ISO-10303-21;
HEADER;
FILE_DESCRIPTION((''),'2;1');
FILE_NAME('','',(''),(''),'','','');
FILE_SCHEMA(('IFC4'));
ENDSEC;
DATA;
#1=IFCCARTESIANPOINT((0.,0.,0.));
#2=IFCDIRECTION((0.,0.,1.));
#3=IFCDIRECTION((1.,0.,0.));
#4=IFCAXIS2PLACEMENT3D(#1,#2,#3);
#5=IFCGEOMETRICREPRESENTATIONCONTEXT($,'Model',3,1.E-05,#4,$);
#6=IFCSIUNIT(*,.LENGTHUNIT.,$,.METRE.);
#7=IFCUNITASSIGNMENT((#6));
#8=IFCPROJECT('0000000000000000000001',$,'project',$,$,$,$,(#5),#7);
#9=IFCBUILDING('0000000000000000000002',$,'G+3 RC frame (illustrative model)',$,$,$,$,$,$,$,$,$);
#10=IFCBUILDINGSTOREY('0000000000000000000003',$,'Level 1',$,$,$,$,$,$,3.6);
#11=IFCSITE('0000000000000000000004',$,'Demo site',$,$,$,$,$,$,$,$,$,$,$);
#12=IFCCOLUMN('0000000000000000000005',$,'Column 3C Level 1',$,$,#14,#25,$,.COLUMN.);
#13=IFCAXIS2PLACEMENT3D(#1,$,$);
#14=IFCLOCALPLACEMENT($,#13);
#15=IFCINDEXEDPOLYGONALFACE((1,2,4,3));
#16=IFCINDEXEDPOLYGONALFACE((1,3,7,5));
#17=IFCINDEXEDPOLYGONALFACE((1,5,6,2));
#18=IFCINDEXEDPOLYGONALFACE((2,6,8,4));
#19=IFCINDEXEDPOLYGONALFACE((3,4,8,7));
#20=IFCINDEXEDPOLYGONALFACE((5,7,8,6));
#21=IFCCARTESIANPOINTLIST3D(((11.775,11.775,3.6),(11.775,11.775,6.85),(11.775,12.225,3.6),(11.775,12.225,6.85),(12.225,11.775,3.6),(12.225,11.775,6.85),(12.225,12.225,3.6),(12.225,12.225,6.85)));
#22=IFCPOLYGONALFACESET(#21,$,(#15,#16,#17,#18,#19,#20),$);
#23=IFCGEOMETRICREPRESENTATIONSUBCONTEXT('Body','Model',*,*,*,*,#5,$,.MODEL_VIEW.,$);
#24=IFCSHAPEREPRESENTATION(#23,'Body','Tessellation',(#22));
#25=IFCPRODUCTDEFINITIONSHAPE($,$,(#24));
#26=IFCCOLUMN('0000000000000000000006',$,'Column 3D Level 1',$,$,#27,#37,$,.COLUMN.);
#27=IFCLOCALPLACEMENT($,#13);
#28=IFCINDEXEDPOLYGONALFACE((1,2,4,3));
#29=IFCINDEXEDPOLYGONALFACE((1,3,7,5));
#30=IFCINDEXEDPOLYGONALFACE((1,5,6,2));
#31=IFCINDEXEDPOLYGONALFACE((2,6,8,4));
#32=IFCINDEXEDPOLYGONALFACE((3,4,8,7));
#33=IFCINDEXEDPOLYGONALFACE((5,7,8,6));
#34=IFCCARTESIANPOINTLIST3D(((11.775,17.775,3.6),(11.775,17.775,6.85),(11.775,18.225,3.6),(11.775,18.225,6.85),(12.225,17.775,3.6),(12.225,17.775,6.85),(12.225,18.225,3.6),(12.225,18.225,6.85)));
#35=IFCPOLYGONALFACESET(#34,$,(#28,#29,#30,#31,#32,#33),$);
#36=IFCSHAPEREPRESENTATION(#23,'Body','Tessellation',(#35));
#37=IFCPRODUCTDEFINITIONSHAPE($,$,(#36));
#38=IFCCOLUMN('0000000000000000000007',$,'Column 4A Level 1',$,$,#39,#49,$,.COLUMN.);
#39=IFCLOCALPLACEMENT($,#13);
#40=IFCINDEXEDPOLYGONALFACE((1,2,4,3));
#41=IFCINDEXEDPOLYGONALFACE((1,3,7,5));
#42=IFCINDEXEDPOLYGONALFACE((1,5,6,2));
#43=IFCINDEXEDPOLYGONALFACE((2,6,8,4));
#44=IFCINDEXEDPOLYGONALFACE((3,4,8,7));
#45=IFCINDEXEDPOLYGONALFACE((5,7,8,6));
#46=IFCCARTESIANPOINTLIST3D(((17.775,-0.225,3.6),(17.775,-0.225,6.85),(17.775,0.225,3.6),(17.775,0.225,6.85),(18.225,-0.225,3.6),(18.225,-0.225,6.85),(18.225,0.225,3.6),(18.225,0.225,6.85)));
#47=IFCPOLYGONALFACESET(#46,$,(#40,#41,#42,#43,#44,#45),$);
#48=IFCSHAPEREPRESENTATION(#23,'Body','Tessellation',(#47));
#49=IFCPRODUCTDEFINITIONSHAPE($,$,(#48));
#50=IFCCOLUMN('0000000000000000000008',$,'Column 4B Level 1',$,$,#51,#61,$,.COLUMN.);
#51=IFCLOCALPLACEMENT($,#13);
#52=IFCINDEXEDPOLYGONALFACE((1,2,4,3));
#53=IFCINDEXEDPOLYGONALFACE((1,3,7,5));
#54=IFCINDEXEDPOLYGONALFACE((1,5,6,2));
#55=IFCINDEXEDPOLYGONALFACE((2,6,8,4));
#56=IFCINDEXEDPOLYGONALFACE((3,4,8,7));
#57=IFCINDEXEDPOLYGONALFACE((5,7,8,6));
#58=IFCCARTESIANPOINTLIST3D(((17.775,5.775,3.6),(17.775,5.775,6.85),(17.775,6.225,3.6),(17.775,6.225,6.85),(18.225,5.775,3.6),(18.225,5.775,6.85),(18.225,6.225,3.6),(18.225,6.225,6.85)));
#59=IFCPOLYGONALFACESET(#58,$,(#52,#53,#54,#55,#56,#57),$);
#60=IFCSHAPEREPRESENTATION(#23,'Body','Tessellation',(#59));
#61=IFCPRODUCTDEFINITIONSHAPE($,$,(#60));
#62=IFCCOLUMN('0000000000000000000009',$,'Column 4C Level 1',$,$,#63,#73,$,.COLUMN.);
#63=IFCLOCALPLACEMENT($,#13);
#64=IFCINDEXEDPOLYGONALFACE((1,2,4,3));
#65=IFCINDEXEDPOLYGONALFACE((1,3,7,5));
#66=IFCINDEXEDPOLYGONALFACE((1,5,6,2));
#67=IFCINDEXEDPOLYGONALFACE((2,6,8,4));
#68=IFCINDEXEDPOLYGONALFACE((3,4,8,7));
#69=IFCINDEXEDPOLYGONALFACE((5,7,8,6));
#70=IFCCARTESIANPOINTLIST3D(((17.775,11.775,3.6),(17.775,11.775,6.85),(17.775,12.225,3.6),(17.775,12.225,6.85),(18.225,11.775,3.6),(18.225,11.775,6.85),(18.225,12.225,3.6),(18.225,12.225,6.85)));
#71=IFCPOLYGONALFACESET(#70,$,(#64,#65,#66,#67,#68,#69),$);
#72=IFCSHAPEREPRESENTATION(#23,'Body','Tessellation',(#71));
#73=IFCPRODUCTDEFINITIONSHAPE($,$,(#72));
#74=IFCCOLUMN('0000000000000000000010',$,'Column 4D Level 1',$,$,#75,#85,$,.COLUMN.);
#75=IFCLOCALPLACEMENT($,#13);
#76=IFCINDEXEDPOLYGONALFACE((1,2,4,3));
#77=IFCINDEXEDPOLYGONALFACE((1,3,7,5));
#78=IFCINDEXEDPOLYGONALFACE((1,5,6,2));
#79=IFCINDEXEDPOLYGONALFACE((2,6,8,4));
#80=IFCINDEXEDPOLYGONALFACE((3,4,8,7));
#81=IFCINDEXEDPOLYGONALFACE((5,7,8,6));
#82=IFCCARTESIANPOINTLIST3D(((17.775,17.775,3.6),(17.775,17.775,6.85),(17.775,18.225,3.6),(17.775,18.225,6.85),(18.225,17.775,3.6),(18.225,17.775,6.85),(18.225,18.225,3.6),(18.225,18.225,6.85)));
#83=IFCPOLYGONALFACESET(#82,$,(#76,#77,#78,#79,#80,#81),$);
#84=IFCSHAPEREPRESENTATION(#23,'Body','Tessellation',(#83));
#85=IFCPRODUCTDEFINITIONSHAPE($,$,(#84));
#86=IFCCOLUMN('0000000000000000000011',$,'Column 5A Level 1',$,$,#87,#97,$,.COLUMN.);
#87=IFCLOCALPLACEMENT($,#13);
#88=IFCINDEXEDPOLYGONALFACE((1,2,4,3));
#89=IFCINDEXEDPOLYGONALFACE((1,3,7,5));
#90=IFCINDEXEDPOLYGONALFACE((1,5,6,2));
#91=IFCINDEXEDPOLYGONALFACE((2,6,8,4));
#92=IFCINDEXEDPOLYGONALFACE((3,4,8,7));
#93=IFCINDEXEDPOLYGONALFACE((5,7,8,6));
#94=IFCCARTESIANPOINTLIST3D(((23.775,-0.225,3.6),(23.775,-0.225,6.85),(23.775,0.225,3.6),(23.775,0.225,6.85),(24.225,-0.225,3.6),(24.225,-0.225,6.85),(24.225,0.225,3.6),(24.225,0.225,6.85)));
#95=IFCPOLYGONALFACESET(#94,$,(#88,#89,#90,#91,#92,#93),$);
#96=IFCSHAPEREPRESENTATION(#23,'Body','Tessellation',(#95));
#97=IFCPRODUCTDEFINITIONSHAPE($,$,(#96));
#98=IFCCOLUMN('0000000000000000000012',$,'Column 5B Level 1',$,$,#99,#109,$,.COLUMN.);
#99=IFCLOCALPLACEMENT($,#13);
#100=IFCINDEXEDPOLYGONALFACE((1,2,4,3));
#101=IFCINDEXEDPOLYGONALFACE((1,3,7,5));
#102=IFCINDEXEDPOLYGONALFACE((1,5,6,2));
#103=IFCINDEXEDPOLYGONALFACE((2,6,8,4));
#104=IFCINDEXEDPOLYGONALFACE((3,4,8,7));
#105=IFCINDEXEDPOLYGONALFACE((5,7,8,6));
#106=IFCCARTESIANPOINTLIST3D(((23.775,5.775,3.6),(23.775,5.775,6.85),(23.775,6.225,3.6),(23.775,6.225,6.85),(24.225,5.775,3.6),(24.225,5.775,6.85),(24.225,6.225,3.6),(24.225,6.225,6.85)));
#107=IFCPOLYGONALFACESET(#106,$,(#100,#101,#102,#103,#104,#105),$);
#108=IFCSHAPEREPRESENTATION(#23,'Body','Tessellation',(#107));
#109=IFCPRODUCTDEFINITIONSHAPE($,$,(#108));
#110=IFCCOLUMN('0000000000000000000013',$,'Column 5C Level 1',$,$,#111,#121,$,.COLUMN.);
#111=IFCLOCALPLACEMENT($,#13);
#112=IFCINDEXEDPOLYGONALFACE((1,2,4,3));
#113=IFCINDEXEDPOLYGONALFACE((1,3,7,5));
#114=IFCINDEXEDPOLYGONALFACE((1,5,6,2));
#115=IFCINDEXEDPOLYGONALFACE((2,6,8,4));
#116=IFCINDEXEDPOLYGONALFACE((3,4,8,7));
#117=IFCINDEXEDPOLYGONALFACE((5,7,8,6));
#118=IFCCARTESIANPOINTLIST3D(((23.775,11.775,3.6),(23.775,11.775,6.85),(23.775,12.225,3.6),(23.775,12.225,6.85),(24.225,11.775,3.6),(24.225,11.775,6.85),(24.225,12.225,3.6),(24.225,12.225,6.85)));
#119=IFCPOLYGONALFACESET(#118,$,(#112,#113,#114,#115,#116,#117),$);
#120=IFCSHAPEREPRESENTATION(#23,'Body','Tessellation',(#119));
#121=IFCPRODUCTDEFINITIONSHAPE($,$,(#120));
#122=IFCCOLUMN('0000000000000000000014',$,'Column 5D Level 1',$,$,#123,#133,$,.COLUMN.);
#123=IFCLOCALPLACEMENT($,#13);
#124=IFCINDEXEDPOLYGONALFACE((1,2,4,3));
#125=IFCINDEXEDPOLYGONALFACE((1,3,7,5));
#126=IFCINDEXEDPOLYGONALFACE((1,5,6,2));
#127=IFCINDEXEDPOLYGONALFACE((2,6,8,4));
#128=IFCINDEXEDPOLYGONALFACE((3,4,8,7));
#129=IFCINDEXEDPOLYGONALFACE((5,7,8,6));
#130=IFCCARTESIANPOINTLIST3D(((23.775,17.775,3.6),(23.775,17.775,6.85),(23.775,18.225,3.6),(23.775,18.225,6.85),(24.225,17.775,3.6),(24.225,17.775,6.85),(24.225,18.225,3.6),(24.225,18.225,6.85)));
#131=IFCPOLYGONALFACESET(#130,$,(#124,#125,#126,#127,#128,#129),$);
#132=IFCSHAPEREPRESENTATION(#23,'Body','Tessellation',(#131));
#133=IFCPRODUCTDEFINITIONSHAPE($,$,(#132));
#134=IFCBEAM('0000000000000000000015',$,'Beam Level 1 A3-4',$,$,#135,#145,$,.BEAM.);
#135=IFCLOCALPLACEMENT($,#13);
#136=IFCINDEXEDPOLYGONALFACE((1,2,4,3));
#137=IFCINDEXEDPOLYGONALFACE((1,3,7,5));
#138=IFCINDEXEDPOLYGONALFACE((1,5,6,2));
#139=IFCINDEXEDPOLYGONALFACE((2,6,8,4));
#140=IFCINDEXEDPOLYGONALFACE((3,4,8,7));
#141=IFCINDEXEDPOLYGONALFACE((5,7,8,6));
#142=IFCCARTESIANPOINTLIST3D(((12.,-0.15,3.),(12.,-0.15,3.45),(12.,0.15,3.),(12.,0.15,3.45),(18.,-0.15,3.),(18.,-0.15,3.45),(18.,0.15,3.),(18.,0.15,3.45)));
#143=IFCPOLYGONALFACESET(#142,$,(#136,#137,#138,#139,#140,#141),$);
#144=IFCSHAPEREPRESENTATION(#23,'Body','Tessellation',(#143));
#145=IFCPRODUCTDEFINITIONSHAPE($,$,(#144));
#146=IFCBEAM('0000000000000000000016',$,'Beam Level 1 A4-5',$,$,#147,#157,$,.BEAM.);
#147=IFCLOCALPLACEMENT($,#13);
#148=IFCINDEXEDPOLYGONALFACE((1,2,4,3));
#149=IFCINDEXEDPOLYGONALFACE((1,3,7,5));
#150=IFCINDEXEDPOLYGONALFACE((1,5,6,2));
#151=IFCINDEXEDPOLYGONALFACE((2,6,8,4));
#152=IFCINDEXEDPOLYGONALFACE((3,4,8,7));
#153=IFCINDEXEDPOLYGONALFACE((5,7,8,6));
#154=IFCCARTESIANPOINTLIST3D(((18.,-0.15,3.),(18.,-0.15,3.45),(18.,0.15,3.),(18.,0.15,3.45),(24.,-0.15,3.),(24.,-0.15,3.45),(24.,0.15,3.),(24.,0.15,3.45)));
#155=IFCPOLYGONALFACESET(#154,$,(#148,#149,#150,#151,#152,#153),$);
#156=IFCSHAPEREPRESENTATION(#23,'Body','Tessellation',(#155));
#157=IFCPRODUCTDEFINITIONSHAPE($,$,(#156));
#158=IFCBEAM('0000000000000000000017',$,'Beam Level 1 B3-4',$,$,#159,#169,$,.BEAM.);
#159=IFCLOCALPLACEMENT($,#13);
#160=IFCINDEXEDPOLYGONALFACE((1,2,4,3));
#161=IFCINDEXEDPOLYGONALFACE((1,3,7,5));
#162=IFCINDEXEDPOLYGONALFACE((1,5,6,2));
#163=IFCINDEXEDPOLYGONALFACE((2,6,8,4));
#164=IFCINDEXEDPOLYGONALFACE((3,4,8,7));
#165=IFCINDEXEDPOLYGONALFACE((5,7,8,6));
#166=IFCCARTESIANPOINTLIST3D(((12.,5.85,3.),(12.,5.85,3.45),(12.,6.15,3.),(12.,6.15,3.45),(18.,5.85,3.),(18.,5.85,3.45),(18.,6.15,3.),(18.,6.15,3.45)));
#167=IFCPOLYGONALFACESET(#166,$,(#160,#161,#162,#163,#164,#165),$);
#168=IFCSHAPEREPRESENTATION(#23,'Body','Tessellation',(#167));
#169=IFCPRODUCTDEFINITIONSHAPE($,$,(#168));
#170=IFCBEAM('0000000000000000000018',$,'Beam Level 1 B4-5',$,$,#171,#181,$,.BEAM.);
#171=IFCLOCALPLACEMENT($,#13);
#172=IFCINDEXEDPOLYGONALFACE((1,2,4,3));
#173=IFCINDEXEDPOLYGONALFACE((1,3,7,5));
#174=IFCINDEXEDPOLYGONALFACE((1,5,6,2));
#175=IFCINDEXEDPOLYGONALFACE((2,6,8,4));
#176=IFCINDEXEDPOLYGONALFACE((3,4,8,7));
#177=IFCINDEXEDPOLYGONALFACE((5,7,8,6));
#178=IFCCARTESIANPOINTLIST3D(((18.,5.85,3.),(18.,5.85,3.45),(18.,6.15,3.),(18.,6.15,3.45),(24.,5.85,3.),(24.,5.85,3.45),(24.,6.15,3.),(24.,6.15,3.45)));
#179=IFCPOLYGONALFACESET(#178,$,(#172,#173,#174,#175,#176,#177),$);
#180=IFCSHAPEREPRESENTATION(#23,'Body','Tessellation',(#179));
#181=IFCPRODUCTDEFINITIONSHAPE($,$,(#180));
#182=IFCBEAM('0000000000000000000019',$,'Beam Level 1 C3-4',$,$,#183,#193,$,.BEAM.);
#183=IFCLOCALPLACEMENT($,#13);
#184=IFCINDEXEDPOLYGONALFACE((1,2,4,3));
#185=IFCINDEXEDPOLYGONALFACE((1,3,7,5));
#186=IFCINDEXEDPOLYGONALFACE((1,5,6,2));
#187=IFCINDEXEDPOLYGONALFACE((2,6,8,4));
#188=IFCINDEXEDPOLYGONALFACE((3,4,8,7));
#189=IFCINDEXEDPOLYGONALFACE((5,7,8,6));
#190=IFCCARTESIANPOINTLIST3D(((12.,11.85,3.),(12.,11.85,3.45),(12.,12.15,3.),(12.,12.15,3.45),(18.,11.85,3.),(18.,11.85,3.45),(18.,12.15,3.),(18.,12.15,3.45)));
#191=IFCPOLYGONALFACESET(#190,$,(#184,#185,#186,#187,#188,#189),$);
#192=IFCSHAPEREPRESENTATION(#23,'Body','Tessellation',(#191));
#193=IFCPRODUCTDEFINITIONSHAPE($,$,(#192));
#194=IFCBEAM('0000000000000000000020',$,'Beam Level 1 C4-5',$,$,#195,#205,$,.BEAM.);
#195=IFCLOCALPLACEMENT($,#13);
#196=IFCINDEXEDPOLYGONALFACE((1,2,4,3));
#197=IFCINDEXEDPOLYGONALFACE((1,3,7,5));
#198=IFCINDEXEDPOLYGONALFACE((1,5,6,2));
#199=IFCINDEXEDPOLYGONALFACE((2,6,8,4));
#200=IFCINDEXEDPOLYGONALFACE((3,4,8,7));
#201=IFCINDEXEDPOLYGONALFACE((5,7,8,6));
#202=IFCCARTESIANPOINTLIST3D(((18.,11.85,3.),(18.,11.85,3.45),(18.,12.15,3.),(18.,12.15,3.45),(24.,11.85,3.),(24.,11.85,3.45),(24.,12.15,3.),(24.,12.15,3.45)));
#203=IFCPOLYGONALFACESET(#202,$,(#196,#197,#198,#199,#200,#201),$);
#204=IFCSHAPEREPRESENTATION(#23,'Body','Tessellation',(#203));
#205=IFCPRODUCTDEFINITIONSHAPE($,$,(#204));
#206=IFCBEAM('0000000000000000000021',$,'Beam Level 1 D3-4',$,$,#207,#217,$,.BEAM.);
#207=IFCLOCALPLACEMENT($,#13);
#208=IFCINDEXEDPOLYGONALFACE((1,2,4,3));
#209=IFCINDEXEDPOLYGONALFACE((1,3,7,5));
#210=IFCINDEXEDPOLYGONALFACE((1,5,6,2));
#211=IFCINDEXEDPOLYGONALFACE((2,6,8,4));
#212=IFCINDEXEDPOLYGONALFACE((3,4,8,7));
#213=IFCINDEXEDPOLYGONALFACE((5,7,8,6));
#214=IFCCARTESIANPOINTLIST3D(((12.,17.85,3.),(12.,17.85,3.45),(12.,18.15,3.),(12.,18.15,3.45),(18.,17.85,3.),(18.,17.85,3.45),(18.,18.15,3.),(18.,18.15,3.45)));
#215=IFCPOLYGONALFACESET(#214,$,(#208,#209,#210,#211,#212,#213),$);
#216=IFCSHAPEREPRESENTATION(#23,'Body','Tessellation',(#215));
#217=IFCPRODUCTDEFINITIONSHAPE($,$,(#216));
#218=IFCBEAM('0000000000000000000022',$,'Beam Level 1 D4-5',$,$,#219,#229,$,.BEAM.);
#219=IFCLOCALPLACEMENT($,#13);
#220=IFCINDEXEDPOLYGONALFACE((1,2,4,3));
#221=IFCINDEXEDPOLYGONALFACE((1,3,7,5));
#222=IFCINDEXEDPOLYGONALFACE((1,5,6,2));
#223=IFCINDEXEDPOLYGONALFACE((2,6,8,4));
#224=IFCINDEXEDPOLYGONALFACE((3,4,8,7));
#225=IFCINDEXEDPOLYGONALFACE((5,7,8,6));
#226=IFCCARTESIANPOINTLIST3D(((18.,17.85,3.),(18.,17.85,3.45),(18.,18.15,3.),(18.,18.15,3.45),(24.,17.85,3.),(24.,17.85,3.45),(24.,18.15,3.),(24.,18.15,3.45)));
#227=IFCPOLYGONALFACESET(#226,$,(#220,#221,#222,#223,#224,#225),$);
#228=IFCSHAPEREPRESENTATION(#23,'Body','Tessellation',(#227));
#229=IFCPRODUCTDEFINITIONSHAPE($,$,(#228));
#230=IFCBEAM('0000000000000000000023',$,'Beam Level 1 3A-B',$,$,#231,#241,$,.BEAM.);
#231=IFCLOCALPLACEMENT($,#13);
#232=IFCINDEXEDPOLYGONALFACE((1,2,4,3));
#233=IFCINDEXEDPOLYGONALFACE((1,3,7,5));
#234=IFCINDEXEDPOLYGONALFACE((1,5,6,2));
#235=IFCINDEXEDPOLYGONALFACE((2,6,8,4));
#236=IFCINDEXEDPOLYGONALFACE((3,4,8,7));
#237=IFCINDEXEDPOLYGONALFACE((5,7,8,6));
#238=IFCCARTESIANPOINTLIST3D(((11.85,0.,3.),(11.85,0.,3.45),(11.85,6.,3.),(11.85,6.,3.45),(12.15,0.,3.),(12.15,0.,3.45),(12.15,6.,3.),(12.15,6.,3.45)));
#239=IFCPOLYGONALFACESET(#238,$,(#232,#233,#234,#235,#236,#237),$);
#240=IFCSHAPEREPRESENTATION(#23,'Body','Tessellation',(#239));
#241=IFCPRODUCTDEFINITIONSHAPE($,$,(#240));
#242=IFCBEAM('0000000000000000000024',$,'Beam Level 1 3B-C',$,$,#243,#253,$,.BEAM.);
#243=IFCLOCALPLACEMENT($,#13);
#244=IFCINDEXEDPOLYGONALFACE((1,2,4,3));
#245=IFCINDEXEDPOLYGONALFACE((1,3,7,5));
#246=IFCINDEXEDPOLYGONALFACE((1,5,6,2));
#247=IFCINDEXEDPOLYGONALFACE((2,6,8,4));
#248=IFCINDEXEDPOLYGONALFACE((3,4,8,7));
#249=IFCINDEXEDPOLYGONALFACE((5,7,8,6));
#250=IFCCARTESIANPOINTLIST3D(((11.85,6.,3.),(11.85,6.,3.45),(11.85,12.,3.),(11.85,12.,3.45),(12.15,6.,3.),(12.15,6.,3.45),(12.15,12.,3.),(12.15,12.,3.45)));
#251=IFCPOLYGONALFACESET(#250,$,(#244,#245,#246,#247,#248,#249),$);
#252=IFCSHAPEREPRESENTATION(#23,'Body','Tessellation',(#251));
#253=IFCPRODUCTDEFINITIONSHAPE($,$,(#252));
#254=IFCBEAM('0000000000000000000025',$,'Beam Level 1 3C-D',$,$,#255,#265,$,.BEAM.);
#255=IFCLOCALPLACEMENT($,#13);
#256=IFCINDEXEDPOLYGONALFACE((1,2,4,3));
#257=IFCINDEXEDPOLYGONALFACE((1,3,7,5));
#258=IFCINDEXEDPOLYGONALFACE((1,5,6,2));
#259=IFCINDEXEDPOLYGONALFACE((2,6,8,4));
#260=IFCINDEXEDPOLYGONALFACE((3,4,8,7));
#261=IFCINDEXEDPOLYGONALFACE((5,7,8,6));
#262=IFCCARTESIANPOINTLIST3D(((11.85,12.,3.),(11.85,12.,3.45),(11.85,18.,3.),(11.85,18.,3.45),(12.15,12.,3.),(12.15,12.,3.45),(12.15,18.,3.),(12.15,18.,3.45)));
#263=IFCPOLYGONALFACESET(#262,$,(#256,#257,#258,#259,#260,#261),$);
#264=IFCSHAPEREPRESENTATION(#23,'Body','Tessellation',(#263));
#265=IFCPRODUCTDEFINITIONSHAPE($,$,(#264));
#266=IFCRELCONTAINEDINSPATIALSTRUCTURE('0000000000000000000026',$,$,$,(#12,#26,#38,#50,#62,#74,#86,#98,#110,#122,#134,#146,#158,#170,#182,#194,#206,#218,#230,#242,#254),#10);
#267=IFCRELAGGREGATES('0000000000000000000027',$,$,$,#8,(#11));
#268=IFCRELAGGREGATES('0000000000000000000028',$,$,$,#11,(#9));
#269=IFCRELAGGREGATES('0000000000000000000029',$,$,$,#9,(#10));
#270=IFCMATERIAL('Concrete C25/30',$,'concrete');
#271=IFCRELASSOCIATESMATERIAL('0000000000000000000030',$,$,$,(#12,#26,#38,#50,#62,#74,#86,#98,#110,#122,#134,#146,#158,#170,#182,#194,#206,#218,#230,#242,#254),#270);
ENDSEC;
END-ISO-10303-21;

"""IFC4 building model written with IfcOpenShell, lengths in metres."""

from ifc_helpers import new_model, si_unit, frame, frame_2d, origin, origin_with_axes, place, context, subcontext, project, spatial, rectangle, extrude, material, element, save


model = new_model("IFC4")

# Units and contexts
model_context = context("Model", 3, precision=1e-05, world=origin_with_axes())
body_context = subcontext(model_context, "Body", "Model", "MODEL_VIEW")
ifc_project = project(units=[si_unit("LENGTHUNIT", "METRE")], contexts=[model_context])

# Site, building, storey
site = spatial("IfcSite", under=ifc_project, Name="Demo site")
building = spatial("IfcBuilding", under=site, Name="G+3 RC frame (illustrative model)")
storey = spatial("IfcBuildingStorey", under=building, Name="Level 1", Elevation=3.6)

# Columns
ifc_material_1 = material(Name="Concrete C25/30", Category="concrete")
for number, where, z_axis, x_axis, name in (
    (1, (11.775, 11.775, 3.6), (0.0, 0.0, 1.0), (1.0, 0.0, 0.0), "Column 3C Level 1"),
    (2, (11.775, 17.775, 3.6), (0.0, 0.0, 1.0), (1.0, 0.0, 0.0), "Column 3D Level 1"),
    (3, (17.775, -0.225, 3.6), (0.0, 0.0, 1.0), (1.0, 0.0, 0.0), "Column 4A Level 1"),
    (4, (17.775, 5.775, 3.6), (0.0, 0.0, 1.0), (1.0, 0.0, 0.0), "Column 4B Level 1"),
    (5, (17.775, 11.775, 3.6), (0.0, 0.0, 1.0), (1.0, 0.0, 0.0), "Column 4C Level 1"),
    (6, (17.775, 17.775, 3.6), (0.0, 0.0, 1.0), (1.0, 0.0, 0.0), "Column 4D Level 1"),
    (7, (23.775, -0.225, 3.6), (0.0, 0.0, 1.0), (1.0, 0.0, 0.0), "Column 5A Level 1"),
    (8, (23.775, 5.775, 3.6), (0.0, 0.0, 1.0), (1.0, 0.0, 0.0), "Column 5B Level 1"),
    (9, (23.775, 11.775, 3.6), (0.0, 0.0, 1.0), (1.0, 0.0, 0.0), "Column 5C Level 1"),
    (10, (23.775, 17.775, 3.6), (0.0, 0.0, 1.0), (1.0, 0.0, 0.0), "Column 5D Level 1"),
):
    element("IfcColumn", number, at=place(None, frame(where, z_axis=z_axis, x_axis=x_axis)), inside=storey, material=ifc_material_1, Name=name, PredefinedType="COLUMN", context=body_context, shape_type="SweptSolid", body=[
        extrude(rectangle(XDim=0.45, YDim=0.45, at=frame_2d((0.225, 0.225))), origin(), (0.0, 0.0, 1.0), 3.25),
    ])

# Beams
for number, where, z_axis, x_axis, name in (
    (11, (12.0, -0.15, 3.0), (0.0, 0.0, 1.0), (1.0, 0.0, 0.0), "Beam Level 1 A3-4"),
    (12, (18.0, -0.15, 3.0), (0.0, 0.0, 1.0), (1.0, 0.0, 0.0), "Beam Level 1 A4-5"),
    (13, (12.0, 5.85, 3.0), (0.0, 0.0, 1.0), (1.0, 0.0, 0.0), "Beam Level 1 B3-4"),
    (14, (18.0, 5.85, 3.0), (0.0, 0.0, 1.0), (1.0, 0.0, 0.0), "Beam Level 1 B4-5"),
    (15, (12.0, 11.85, 3.0), (0.0, 0.0, 1.0), (1.0, 0.0, 0.0), "Beam Level 1 C3-4"),
    (16, (18.0, 11.85, 3.0), (0.0, 0.0, 1.0), (1.0, 0.0, 0.0), "Beam Level 1 C4-5"),
    (17, (12.0, 17.85, 3.0), (0.0, 0.0, 1.0), (1.0, 0.0, 0.0), "Beam Level 1 D3-4"),
    (18, (18.0, 17.85, 3.0), (0.0, 0.0, 1.0), (1.0, 0.0, 0.0), "Beam Level 1 D4-5"),
):
    element("IfcBeam", number, at=place(None, frame(where, z_axis=z_axis, x_axis=x_axis)), inside=storey, material=ifc_material_1, Name=name, PredefinedType="BEAM", context=body_context, shape_type="SweptSolid", body=[
        extrude(rectangle(XDim=6.0, YDim=0.3, at=frame_2d((3.0, 0.15))), origin(), (0.0, 0.0, 1.0), 0.45),
    ])
for number, where, z_axis, x_axis, name in (
    (19, (11.85, 0.0, 3.0), (0.0, 0.0, 1.0), (1.0, 0.0, 0.0), "Beam Level 1 3A-B"),
    (20, (11.85, 6.0, 3.0), (0.0, 0.0, 1.0), (1.0, 0.0, 0.0), "Beam Level 1 3B-C"),
    (21, (11.85, 12.0, 3.0), (0.0, 0.0, 1.0), (1.0, 0.0, 0.0), "Beam Level 1 3C-D"),
):
    element("IfcBeam", number, at=place(None, frame(where, z_axis=z_axis, x_axis=x_axis)), inside=storey, material=ifc_material_1, Name=name, PredefinedType="BEAM", context=body_context, shape_type="SweptSolid", body=[
        extrude(rectangle(XDim=0.3, YDim=6.0, at=frame_2d((0.15, 3.0))), origin(), (0.0, 0.0, 1.0), 0.45),
    ])

save(model, "model.ifc")
